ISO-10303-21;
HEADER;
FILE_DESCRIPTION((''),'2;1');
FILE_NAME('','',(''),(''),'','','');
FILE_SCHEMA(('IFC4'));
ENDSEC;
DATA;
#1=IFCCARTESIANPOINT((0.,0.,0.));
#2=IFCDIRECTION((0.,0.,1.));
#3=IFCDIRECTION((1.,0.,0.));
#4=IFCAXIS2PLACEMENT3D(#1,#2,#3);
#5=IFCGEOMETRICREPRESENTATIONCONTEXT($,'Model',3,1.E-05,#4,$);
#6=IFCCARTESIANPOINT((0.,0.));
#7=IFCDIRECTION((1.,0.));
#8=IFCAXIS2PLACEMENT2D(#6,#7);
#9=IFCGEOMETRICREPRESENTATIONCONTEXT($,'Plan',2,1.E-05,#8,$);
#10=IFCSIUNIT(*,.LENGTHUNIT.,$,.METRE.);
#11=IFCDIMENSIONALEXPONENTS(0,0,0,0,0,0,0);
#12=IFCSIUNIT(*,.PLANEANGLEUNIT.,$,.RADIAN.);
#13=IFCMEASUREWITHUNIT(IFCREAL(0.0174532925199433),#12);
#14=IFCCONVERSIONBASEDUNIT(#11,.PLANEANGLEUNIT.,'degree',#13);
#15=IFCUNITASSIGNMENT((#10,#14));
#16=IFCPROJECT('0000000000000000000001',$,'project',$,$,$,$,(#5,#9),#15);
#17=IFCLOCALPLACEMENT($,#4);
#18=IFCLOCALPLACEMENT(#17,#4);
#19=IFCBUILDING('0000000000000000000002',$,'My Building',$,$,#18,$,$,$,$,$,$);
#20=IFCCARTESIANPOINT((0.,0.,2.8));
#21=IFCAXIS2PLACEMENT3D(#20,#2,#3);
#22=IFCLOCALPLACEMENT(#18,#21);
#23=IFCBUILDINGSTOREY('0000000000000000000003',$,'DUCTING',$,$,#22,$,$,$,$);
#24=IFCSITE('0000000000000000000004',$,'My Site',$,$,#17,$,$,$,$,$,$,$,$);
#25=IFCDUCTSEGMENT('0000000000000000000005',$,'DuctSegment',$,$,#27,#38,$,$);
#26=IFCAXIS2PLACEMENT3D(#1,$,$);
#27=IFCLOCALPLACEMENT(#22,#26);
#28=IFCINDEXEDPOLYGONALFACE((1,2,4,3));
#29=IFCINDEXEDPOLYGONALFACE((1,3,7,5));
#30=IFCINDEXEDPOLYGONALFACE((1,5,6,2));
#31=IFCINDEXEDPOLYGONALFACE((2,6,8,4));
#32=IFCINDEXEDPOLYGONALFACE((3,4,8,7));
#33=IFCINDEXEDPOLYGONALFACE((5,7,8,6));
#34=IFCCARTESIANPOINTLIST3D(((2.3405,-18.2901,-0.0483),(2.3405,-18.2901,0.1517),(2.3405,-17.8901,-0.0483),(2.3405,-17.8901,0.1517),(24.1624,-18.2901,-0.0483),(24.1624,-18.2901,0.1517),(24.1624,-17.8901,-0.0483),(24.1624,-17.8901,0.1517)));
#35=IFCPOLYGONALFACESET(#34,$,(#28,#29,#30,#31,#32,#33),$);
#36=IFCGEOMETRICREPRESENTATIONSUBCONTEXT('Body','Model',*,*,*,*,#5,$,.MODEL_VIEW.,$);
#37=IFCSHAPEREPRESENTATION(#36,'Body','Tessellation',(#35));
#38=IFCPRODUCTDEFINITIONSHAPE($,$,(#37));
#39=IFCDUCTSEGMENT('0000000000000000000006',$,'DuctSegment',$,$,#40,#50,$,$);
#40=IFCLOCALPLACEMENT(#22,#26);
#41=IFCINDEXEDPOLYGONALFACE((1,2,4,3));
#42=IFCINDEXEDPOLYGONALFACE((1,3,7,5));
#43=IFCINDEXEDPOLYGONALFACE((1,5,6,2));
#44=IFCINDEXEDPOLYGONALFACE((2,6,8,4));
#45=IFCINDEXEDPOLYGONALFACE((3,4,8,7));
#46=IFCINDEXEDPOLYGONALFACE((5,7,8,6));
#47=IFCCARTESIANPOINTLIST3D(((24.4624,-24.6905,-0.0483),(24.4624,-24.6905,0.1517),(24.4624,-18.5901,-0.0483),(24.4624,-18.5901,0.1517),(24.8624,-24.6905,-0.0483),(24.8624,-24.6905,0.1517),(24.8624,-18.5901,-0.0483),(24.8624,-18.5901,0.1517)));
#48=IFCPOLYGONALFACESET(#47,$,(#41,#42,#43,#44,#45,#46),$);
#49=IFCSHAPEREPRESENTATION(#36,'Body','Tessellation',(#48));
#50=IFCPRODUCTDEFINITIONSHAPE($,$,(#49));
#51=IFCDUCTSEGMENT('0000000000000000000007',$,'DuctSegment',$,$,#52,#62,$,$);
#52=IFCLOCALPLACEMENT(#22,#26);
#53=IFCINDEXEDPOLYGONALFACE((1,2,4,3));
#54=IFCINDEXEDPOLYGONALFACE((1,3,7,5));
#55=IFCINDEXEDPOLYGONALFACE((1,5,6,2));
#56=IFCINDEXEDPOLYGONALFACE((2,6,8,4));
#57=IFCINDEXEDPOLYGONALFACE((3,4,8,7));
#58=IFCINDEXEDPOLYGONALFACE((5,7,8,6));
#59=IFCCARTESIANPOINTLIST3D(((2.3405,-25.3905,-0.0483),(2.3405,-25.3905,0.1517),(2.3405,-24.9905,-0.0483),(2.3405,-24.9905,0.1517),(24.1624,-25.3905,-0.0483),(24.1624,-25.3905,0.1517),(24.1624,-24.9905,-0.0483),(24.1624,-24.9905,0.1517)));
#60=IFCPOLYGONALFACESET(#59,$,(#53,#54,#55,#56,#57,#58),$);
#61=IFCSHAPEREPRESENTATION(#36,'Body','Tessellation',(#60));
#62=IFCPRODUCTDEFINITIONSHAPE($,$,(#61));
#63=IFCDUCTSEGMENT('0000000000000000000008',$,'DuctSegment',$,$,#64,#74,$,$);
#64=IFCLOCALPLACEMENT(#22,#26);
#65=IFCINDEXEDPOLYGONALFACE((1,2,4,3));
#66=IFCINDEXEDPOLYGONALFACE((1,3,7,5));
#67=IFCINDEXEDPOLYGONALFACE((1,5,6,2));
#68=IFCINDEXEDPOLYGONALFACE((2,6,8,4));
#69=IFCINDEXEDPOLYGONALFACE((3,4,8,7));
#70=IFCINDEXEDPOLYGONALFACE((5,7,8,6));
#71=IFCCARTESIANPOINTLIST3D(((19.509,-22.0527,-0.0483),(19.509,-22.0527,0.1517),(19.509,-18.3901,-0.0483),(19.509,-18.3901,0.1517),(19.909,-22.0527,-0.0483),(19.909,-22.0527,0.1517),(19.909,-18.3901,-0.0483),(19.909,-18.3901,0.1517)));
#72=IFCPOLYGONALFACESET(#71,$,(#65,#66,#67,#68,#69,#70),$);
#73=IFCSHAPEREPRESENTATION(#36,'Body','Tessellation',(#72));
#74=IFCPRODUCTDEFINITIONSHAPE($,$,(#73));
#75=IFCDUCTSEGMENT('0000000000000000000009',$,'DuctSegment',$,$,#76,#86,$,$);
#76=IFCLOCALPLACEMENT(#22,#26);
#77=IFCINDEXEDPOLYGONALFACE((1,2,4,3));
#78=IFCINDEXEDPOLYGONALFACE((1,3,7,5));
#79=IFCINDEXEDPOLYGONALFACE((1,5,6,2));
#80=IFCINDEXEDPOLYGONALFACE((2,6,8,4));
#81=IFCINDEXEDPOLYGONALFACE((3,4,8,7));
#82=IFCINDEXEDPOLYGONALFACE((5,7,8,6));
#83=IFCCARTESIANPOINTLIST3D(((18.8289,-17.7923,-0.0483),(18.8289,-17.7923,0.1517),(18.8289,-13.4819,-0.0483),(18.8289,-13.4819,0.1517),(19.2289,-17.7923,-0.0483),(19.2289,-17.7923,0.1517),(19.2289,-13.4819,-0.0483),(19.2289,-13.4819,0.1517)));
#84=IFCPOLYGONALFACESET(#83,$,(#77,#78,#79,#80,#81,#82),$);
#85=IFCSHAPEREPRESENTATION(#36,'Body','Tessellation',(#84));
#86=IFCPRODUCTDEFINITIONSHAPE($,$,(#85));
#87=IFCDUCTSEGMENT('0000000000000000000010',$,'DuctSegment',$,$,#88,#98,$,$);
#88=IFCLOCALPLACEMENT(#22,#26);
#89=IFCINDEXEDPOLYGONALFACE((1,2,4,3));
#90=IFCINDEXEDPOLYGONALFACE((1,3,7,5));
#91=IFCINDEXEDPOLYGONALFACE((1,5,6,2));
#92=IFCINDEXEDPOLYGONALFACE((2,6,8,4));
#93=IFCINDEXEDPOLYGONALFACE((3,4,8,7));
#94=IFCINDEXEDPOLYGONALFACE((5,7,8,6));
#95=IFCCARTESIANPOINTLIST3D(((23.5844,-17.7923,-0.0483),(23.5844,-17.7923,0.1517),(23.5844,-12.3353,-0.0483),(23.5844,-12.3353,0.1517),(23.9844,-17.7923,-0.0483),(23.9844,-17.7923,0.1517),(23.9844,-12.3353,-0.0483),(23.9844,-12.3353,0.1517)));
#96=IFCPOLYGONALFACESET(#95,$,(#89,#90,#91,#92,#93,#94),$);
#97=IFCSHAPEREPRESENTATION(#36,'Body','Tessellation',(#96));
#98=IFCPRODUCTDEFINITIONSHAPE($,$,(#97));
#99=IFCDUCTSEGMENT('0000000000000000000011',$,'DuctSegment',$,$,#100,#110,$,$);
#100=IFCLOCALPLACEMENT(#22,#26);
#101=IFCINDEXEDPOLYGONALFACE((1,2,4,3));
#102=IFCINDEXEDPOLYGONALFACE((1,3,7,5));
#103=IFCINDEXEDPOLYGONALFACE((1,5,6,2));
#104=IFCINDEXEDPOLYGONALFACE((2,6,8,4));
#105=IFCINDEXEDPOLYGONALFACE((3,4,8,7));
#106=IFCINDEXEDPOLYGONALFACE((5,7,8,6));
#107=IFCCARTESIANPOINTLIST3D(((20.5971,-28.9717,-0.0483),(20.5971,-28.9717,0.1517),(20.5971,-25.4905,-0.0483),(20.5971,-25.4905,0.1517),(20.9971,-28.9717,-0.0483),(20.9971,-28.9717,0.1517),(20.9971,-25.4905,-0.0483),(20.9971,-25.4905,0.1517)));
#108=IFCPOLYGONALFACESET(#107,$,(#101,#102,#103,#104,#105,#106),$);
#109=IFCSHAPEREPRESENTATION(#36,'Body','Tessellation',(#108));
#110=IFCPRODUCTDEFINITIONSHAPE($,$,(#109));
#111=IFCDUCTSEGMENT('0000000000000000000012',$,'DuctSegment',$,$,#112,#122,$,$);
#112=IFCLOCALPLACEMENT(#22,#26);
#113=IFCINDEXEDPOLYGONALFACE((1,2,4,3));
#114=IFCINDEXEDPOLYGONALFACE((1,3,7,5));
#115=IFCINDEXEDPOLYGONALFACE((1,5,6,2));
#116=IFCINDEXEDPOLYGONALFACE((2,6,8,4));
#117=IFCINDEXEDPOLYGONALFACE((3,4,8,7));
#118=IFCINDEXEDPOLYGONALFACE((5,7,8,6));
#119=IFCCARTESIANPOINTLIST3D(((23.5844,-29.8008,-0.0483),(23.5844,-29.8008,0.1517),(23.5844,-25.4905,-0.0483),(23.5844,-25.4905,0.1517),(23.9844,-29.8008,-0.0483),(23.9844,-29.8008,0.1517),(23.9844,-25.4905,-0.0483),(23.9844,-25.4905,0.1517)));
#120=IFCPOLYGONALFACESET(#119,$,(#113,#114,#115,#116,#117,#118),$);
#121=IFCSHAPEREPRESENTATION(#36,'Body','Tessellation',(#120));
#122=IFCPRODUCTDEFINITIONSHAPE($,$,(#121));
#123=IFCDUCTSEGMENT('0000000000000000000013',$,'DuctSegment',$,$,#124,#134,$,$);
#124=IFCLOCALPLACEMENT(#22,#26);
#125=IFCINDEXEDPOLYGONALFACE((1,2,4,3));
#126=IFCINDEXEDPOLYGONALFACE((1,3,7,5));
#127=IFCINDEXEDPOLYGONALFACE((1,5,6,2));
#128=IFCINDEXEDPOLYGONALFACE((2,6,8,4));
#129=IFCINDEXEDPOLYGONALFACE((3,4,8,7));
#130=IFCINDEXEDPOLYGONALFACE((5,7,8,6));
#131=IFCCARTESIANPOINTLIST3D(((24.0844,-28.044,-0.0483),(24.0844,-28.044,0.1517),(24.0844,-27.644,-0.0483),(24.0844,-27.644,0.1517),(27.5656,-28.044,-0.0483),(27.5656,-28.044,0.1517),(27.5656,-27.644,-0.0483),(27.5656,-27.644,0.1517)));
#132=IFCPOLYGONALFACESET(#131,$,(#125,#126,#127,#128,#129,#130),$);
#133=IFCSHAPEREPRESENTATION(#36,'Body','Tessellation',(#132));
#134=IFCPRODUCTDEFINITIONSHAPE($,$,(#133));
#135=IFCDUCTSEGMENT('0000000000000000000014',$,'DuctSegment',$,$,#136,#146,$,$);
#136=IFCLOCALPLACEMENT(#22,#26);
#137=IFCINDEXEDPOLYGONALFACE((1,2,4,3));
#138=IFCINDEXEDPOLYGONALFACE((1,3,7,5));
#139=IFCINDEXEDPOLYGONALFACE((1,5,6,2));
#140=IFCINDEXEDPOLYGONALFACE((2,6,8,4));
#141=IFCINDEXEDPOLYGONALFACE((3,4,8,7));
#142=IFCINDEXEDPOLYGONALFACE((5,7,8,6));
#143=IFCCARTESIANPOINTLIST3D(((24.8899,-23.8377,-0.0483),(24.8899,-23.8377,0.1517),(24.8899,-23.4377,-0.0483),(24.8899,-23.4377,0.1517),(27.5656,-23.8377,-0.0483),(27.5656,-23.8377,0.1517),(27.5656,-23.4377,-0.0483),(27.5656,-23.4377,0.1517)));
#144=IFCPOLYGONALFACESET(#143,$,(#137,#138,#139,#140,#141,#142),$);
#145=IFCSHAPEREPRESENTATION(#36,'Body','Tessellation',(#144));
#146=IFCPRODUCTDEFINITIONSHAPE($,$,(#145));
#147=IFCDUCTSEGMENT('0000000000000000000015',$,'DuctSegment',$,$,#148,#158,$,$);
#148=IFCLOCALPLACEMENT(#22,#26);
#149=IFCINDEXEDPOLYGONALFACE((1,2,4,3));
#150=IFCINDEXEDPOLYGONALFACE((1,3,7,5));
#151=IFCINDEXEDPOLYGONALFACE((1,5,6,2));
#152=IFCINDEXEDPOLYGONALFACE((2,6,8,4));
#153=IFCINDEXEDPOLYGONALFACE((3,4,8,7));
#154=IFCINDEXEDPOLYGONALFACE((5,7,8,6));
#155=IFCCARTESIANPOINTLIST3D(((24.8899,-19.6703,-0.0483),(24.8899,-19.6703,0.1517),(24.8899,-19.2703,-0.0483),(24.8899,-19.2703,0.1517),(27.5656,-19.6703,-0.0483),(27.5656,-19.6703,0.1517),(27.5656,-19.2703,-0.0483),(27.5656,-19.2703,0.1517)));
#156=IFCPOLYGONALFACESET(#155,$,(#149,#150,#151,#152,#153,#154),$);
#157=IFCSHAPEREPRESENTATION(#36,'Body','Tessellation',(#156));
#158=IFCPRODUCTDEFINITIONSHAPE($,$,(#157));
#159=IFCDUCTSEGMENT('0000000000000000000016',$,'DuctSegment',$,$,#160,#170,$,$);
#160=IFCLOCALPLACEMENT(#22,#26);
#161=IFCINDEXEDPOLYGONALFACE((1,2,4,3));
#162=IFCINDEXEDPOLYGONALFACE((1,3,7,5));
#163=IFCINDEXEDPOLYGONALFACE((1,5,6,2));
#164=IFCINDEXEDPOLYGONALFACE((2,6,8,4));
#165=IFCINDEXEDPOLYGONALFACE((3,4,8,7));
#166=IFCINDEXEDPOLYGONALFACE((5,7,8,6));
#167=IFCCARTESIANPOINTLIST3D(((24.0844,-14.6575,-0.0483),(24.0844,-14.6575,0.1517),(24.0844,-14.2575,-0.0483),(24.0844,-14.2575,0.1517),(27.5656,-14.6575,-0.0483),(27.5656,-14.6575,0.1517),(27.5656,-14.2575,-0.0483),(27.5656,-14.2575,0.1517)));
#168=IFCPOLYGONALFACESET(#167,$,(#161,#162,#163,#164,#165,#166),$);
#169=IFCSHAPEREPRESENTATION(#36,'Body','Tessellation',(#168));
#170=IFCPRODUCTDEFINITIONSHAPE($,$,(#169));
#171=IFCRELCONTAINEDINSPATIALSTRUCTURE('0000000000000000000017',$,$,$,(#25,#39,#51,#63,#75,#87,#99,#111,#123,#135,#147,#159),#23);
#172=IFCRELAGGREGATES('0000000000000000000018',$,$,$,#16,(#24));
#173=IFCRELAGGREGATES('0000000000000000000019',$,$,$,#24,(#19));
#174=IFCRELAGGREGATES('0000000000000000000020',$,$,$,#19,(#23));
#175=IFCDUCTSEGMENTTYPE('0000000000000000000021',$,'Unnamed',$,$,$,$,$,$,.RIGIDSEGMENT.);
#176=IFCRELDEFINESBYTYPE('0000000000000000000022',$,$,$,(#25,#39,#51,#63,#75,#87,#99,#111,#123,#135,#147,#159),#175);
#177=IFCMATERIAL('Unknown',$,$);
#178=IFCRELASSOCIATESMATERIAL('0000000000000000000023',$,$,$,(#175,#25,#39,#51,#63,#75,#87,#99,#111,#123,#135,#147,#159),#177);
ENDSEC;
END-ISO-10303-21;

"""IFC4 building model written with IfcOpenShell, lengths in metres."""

from ifc_helpers import new_model, entity, si_unit, converted_unit, frame, origin_with_axes, origin_2d_with_axis, place, context, subcontext, project, spatial, rectangle, extrude, material, material_profile, profile_set, profile_usage, type_object, element, save


model = new_model("IFC4")

# Units and contexts
model_context = context("Model", 3, precision=1e-05, world=origin_with_axes())
plan_context = context("Plan", 2, precision=1e-05, world=origin_2d_with_axis())
body_context = subcontext(model_context, "Body", "Model", "MODEL_VIEW")
ifc_project = project(units=[si_unit("LENGTHUNIT", "METRE"), converted_unit("PLANEANGLEUNIT", "degree", entity("IfcReal", 0.0174532925199433), si_unit("PLANEANGLEUNIT", "RADIAN"), dimensions=[0, 0, 0, 0, 0, 0, 0])], contexts=[model_context, plan_context])

# Site, building, storey
site_placement = place(None, origin_with_axes())
site = spatial("IfcSite", under=ifc_project, at=site_placement, Name="My Site")
building_placement = place(site_placement, origin_with_axes())
building = spatial("IfcBuilding", under=site, at=building_placement, Name="My Building")
storey_placement = place(building_placement, frame((0.0, 0.0, 2.8), z_axis=(0.0, 0.0, 1.0), x_axis=(1.0, 0.0, 0.0)))
storey = spatial("IfcBuildingStorey", under=building, at=storey_placement, Name="DUCTING")

# Duct segments
ifc_material = material(Name="Unknown")
ifc_material_profile_1 = material_profile(ifc_material, rectangle(XDim=0.4, YDim=0.2))
ifc_profile_set_1 = profile_set([ifc_material_profile_1])
ifc_profile_usage_1 = profile_usage(ifc_profile_set_1, cardinal=5)
duct_segment_type = type_object("IfcDuctSegmentType", Name="Unnamed", PredefinedType="RIGIDSEGMENT", material=ifc_profile_set_1)
duct_segment_1_placement = place(storey_placement, frame((24.1624, -18.0901, 0.0517), z_axis=(-1.0, 0.0, 0.0), x_axis=(0.0, -1.0, 0.0)))
element("IfcDuctSegment", 1, at=duct_segment_1_placement, inside=storey, type_object=duct_segment_type, material=ifc_profile_usage_1, Name="DuctSegment", context=body_context, shape_type="SweptSolid", body=[
    extrude(rectangle(XDim=0.4, YDim=0.2), origin_with_axes(), (0.0, 0.0, 1.0), 21.8219),
])
ifc_profile_usage_2 = profile_usage(ifc_profile_set_1, cardinal=5)
duct_segment_2_placement = place(storey_placement, frame((24.6624, -18.5901, 0.0517), z_axis=(0.0, -1.0, 0.0), x_axis=(1.0, 0.0, 0.0)))
element("IfcDuctSegment", 2, at=duct_segment_2_placement, inside=storey, type_object=duct_segment_type, material=ifc_profile_usage_2, Name="DuctSegment", context=body_context, shape_type="SweptSolid", body=[
    extrude(rectangle(XDim=0.4, YDim=0.2), origin_with_axes(), (0.0, 0.0, 1.0), 6.1004),
])
ifc_profile_usage_3 = profile_usage(ifc_profile_set_1, cardinal=5)
duct_segment_3_placement = place(storey_placement, frame((24.1624, -25.1905, 0.0517), z_axis=(-1.0, 0.0, 0.0), x_axis=(0.0, -1.0, 0.0)))
element("IfcDuctSegment", 3, at=duct_segment_3_placement, inside=storey, type_object=duct_segment_type, material=ifc_profile_usage_3, Name="DuctSegment", context=body_context, shape_type="SweptSolid", body=[
    extrude(rectangle(XDim=0.4, YDim=0.2), origin_with_axes(), (0.0, 0.0, 1.0), 21.8219),
])
ifc_profile_usage_4 = profile_usage(ifc_profile_set_1, cardinal=5)
duct_segment_4_placement = place(storey_placement, frame((19.709, -22.0527, 0.0517), z_axis=(0.0, 1.0, 0.0), x_axis=(-1.0, 0.0, 0.0)))
element("IfcDuctSegment", 4, at=duct_segment_4_placement, inside=storey, type_object=duct_segment_type, material=ifc_profile_usage_4, Name="DuctSegment", context=body_context, shape_type="SweptSolid", body=[
    extrude(rectangle(XDim=0.4, YDim=0.2), origin_with_axes(), (0.0, 0.0, 1.0), 3.6626),
])
ifc_profile_usage_5 = profile_usage(ifc_profile_set_1, cardinal=5)
duct_segment_5_placement = place(storey_placement, frame((19.0289, -13.4819, 0.0517), z_axis=(0.0, -1.0, 0.0), x_axis=(1.0, 0.0, 0.0)))
element("IfcDuctSegment", 5, at=duct_segment_5_placement, inside=storey, type_object=duct_segment_type, material=ifc_profile_usage_5, Name="DuctSegment", context=body_context, shape_type="SweptSolid", body=[
    extrude(rectangle(XDim=0.4, YDim=0.2), origin_with_axes(), (0.0, 0.0, 1.0), 4.3103),
])
ifc_profile_usage_6 = profile_usage(ifc_profile_set_1, cardinal=5)
duct_segment_6_placement = place(storey_placement, frame((23.7844, -12.3353, 0.0517), z_axis=(0.0, -1.0, 0.0), x_axis=(1.0, 0.0, 0.0)))
element("IfcDuctSegment", 6, at=duct_segment_6_placement, inside=storey, type_object=duct_segment_type, material=ifc_profile_usage_6, Name="DuctSegment", context=body_context, shape_type="SweptSolid", body=[
    extrude(rectangle(XDim=0.4, YDim=0.2), origin_with_axes(), (0.0, 0.0, 1.0), 5.457),
])
ifc_profile_usage_7 = profile_usage(ifc_profile_set_1, cardinal=5)
duct_segment_7_placement = place(storey_placement, frame((20.7971, -28.9717, 0.0517), z_axis=(0.0, 1.0, 0.0), x_axis=(-1.0, 0.0, 0.0)))
element("IfcDuctSegment", 7, at=duct_segment_7_placement, inside=storey, type_object=duct_segment_type, material=ifc_profile_usage_7, Name="DuctSegment", context=body_context, shape_type="SweptSolid", body=[
    extrude(rectangle(XDim=0.4, YDim=0.2), origin_with_axes(), (0.0, 0.0, 1.0), 3.4812),
])
ifc_profile_usage_8 = profile_usage(ifc_profile_set_1, cardinal=5)
duct_segment_8_placement = place(storey_placement, frame((23.7844, -29.8008, 0.0517), z_axis=(0.0, 1.0, 0.0), x_axis=(-1.0, 0.0, 0.0)))
element("IfcDuctSegment", 8, at=duct_segment_8_placement, inside=storey, type_object=duct_segment_type, material=ifc_profile_usage_8, Name="DuctSegment", context=body_context, shape_type="SweptSolid", body=[
    extrude(rectangle(XDim=0.4, YDim=0.2), origin_with_axes(), (0.0, 0.0, 1.0), 4.3103),
])
ifc_profile_usage_9 = profile_usage(ifc_profile_set_1, cardinal=5)
duct_segment_9_placement = place(storey_placement, frame((27.5656, -27.844, 0.0517), z_axis=(-1.0, 0.0, 0.0), x_axis=(0.0, -1.0, 0.0)))
element("IfcDuctSegment", 9, at=duct_segment_9_placement, inside=storey, type_object=duct_segment_type, material=ifc_profile_usage_9, Name="DuctSegment", context=body_context, shape_type="SweptSolid", body=[
    extrude(rectangle(XDim=0.4, YDim=0.2), origin_with_axes(), (0.0, 0.0, 1.0), 3.4812),
])
ifc_profile_usage_10 = profile_usage(ifc_profile_set_1, cardinal=5)
duct_segment_10_placement = place(storey_placement, frame((27.5656, -23.6377, 0.0517), z_axis=(-1.0, 0.0, 0.0), x_axis=(0.0, -1.0, 0.0)))
element("IfcDuctSegment", 10, at=duct_segment_10_placement, inside=storey, type_object=duct_segment_type, material=ifc_profile_usage_10, Name="DuctSegment", context=body_context, shape_type="SweptSolid", body=[
    extrude(rectangle(XDim=0.4, YDim=0.2), origin_with_axes(), (0.0, 0.0, 1.0), 2.6757),
])
ifc_profile_usage_11 = profile_usage(ifc_profile_set_1, cardinal=5)
duct_segment_11_placement = place(storey_placement, frame((27.5656, -19.4703, 0.0517), z_axis=(-1.0, 0.0, 0.0), x_axis=(0.0, -1.0, 0.0)))
element("IfcDuctSegment", 11, at=duct_segment_11_placement, inside=storey, type_object=duct_segment_type, material=ifc_profile_usage_11, Name="DuctSegment", context=body_context, shape_type="SweptSolid", body=[
    extrude(rectangle(XDim=0.4, YDim=0.2), origin_with_axes(), (0.0, 0.0, 1.0), 2.6757),
])
ifc_profile_usage_12 = profile_usage(ifc_profile_set_1, cardinal=5)
duct_segment_12_placement = place(storey_placement, frame((27.5656, -14.4575, 0.0517), z_axis=(-1.0, 0.0, 0.0), x_axis=(0.0, -1.0, 0.0)))
element("IfcDuctSegment", 12, at=duct_segment_12_placement, inside=storey, type_object=duct_segment_type, material=ifc_profile_usage_12, Name="DuctSegment", context=body_context, shape_type="SweptSolid", body=[
    extrude(rectangle(XDim=0.4, YDim=0.2), origin_with_axes(), (0.0, 0.0, 1.0), 3.4812),
])

save(model, "model.ifc")
